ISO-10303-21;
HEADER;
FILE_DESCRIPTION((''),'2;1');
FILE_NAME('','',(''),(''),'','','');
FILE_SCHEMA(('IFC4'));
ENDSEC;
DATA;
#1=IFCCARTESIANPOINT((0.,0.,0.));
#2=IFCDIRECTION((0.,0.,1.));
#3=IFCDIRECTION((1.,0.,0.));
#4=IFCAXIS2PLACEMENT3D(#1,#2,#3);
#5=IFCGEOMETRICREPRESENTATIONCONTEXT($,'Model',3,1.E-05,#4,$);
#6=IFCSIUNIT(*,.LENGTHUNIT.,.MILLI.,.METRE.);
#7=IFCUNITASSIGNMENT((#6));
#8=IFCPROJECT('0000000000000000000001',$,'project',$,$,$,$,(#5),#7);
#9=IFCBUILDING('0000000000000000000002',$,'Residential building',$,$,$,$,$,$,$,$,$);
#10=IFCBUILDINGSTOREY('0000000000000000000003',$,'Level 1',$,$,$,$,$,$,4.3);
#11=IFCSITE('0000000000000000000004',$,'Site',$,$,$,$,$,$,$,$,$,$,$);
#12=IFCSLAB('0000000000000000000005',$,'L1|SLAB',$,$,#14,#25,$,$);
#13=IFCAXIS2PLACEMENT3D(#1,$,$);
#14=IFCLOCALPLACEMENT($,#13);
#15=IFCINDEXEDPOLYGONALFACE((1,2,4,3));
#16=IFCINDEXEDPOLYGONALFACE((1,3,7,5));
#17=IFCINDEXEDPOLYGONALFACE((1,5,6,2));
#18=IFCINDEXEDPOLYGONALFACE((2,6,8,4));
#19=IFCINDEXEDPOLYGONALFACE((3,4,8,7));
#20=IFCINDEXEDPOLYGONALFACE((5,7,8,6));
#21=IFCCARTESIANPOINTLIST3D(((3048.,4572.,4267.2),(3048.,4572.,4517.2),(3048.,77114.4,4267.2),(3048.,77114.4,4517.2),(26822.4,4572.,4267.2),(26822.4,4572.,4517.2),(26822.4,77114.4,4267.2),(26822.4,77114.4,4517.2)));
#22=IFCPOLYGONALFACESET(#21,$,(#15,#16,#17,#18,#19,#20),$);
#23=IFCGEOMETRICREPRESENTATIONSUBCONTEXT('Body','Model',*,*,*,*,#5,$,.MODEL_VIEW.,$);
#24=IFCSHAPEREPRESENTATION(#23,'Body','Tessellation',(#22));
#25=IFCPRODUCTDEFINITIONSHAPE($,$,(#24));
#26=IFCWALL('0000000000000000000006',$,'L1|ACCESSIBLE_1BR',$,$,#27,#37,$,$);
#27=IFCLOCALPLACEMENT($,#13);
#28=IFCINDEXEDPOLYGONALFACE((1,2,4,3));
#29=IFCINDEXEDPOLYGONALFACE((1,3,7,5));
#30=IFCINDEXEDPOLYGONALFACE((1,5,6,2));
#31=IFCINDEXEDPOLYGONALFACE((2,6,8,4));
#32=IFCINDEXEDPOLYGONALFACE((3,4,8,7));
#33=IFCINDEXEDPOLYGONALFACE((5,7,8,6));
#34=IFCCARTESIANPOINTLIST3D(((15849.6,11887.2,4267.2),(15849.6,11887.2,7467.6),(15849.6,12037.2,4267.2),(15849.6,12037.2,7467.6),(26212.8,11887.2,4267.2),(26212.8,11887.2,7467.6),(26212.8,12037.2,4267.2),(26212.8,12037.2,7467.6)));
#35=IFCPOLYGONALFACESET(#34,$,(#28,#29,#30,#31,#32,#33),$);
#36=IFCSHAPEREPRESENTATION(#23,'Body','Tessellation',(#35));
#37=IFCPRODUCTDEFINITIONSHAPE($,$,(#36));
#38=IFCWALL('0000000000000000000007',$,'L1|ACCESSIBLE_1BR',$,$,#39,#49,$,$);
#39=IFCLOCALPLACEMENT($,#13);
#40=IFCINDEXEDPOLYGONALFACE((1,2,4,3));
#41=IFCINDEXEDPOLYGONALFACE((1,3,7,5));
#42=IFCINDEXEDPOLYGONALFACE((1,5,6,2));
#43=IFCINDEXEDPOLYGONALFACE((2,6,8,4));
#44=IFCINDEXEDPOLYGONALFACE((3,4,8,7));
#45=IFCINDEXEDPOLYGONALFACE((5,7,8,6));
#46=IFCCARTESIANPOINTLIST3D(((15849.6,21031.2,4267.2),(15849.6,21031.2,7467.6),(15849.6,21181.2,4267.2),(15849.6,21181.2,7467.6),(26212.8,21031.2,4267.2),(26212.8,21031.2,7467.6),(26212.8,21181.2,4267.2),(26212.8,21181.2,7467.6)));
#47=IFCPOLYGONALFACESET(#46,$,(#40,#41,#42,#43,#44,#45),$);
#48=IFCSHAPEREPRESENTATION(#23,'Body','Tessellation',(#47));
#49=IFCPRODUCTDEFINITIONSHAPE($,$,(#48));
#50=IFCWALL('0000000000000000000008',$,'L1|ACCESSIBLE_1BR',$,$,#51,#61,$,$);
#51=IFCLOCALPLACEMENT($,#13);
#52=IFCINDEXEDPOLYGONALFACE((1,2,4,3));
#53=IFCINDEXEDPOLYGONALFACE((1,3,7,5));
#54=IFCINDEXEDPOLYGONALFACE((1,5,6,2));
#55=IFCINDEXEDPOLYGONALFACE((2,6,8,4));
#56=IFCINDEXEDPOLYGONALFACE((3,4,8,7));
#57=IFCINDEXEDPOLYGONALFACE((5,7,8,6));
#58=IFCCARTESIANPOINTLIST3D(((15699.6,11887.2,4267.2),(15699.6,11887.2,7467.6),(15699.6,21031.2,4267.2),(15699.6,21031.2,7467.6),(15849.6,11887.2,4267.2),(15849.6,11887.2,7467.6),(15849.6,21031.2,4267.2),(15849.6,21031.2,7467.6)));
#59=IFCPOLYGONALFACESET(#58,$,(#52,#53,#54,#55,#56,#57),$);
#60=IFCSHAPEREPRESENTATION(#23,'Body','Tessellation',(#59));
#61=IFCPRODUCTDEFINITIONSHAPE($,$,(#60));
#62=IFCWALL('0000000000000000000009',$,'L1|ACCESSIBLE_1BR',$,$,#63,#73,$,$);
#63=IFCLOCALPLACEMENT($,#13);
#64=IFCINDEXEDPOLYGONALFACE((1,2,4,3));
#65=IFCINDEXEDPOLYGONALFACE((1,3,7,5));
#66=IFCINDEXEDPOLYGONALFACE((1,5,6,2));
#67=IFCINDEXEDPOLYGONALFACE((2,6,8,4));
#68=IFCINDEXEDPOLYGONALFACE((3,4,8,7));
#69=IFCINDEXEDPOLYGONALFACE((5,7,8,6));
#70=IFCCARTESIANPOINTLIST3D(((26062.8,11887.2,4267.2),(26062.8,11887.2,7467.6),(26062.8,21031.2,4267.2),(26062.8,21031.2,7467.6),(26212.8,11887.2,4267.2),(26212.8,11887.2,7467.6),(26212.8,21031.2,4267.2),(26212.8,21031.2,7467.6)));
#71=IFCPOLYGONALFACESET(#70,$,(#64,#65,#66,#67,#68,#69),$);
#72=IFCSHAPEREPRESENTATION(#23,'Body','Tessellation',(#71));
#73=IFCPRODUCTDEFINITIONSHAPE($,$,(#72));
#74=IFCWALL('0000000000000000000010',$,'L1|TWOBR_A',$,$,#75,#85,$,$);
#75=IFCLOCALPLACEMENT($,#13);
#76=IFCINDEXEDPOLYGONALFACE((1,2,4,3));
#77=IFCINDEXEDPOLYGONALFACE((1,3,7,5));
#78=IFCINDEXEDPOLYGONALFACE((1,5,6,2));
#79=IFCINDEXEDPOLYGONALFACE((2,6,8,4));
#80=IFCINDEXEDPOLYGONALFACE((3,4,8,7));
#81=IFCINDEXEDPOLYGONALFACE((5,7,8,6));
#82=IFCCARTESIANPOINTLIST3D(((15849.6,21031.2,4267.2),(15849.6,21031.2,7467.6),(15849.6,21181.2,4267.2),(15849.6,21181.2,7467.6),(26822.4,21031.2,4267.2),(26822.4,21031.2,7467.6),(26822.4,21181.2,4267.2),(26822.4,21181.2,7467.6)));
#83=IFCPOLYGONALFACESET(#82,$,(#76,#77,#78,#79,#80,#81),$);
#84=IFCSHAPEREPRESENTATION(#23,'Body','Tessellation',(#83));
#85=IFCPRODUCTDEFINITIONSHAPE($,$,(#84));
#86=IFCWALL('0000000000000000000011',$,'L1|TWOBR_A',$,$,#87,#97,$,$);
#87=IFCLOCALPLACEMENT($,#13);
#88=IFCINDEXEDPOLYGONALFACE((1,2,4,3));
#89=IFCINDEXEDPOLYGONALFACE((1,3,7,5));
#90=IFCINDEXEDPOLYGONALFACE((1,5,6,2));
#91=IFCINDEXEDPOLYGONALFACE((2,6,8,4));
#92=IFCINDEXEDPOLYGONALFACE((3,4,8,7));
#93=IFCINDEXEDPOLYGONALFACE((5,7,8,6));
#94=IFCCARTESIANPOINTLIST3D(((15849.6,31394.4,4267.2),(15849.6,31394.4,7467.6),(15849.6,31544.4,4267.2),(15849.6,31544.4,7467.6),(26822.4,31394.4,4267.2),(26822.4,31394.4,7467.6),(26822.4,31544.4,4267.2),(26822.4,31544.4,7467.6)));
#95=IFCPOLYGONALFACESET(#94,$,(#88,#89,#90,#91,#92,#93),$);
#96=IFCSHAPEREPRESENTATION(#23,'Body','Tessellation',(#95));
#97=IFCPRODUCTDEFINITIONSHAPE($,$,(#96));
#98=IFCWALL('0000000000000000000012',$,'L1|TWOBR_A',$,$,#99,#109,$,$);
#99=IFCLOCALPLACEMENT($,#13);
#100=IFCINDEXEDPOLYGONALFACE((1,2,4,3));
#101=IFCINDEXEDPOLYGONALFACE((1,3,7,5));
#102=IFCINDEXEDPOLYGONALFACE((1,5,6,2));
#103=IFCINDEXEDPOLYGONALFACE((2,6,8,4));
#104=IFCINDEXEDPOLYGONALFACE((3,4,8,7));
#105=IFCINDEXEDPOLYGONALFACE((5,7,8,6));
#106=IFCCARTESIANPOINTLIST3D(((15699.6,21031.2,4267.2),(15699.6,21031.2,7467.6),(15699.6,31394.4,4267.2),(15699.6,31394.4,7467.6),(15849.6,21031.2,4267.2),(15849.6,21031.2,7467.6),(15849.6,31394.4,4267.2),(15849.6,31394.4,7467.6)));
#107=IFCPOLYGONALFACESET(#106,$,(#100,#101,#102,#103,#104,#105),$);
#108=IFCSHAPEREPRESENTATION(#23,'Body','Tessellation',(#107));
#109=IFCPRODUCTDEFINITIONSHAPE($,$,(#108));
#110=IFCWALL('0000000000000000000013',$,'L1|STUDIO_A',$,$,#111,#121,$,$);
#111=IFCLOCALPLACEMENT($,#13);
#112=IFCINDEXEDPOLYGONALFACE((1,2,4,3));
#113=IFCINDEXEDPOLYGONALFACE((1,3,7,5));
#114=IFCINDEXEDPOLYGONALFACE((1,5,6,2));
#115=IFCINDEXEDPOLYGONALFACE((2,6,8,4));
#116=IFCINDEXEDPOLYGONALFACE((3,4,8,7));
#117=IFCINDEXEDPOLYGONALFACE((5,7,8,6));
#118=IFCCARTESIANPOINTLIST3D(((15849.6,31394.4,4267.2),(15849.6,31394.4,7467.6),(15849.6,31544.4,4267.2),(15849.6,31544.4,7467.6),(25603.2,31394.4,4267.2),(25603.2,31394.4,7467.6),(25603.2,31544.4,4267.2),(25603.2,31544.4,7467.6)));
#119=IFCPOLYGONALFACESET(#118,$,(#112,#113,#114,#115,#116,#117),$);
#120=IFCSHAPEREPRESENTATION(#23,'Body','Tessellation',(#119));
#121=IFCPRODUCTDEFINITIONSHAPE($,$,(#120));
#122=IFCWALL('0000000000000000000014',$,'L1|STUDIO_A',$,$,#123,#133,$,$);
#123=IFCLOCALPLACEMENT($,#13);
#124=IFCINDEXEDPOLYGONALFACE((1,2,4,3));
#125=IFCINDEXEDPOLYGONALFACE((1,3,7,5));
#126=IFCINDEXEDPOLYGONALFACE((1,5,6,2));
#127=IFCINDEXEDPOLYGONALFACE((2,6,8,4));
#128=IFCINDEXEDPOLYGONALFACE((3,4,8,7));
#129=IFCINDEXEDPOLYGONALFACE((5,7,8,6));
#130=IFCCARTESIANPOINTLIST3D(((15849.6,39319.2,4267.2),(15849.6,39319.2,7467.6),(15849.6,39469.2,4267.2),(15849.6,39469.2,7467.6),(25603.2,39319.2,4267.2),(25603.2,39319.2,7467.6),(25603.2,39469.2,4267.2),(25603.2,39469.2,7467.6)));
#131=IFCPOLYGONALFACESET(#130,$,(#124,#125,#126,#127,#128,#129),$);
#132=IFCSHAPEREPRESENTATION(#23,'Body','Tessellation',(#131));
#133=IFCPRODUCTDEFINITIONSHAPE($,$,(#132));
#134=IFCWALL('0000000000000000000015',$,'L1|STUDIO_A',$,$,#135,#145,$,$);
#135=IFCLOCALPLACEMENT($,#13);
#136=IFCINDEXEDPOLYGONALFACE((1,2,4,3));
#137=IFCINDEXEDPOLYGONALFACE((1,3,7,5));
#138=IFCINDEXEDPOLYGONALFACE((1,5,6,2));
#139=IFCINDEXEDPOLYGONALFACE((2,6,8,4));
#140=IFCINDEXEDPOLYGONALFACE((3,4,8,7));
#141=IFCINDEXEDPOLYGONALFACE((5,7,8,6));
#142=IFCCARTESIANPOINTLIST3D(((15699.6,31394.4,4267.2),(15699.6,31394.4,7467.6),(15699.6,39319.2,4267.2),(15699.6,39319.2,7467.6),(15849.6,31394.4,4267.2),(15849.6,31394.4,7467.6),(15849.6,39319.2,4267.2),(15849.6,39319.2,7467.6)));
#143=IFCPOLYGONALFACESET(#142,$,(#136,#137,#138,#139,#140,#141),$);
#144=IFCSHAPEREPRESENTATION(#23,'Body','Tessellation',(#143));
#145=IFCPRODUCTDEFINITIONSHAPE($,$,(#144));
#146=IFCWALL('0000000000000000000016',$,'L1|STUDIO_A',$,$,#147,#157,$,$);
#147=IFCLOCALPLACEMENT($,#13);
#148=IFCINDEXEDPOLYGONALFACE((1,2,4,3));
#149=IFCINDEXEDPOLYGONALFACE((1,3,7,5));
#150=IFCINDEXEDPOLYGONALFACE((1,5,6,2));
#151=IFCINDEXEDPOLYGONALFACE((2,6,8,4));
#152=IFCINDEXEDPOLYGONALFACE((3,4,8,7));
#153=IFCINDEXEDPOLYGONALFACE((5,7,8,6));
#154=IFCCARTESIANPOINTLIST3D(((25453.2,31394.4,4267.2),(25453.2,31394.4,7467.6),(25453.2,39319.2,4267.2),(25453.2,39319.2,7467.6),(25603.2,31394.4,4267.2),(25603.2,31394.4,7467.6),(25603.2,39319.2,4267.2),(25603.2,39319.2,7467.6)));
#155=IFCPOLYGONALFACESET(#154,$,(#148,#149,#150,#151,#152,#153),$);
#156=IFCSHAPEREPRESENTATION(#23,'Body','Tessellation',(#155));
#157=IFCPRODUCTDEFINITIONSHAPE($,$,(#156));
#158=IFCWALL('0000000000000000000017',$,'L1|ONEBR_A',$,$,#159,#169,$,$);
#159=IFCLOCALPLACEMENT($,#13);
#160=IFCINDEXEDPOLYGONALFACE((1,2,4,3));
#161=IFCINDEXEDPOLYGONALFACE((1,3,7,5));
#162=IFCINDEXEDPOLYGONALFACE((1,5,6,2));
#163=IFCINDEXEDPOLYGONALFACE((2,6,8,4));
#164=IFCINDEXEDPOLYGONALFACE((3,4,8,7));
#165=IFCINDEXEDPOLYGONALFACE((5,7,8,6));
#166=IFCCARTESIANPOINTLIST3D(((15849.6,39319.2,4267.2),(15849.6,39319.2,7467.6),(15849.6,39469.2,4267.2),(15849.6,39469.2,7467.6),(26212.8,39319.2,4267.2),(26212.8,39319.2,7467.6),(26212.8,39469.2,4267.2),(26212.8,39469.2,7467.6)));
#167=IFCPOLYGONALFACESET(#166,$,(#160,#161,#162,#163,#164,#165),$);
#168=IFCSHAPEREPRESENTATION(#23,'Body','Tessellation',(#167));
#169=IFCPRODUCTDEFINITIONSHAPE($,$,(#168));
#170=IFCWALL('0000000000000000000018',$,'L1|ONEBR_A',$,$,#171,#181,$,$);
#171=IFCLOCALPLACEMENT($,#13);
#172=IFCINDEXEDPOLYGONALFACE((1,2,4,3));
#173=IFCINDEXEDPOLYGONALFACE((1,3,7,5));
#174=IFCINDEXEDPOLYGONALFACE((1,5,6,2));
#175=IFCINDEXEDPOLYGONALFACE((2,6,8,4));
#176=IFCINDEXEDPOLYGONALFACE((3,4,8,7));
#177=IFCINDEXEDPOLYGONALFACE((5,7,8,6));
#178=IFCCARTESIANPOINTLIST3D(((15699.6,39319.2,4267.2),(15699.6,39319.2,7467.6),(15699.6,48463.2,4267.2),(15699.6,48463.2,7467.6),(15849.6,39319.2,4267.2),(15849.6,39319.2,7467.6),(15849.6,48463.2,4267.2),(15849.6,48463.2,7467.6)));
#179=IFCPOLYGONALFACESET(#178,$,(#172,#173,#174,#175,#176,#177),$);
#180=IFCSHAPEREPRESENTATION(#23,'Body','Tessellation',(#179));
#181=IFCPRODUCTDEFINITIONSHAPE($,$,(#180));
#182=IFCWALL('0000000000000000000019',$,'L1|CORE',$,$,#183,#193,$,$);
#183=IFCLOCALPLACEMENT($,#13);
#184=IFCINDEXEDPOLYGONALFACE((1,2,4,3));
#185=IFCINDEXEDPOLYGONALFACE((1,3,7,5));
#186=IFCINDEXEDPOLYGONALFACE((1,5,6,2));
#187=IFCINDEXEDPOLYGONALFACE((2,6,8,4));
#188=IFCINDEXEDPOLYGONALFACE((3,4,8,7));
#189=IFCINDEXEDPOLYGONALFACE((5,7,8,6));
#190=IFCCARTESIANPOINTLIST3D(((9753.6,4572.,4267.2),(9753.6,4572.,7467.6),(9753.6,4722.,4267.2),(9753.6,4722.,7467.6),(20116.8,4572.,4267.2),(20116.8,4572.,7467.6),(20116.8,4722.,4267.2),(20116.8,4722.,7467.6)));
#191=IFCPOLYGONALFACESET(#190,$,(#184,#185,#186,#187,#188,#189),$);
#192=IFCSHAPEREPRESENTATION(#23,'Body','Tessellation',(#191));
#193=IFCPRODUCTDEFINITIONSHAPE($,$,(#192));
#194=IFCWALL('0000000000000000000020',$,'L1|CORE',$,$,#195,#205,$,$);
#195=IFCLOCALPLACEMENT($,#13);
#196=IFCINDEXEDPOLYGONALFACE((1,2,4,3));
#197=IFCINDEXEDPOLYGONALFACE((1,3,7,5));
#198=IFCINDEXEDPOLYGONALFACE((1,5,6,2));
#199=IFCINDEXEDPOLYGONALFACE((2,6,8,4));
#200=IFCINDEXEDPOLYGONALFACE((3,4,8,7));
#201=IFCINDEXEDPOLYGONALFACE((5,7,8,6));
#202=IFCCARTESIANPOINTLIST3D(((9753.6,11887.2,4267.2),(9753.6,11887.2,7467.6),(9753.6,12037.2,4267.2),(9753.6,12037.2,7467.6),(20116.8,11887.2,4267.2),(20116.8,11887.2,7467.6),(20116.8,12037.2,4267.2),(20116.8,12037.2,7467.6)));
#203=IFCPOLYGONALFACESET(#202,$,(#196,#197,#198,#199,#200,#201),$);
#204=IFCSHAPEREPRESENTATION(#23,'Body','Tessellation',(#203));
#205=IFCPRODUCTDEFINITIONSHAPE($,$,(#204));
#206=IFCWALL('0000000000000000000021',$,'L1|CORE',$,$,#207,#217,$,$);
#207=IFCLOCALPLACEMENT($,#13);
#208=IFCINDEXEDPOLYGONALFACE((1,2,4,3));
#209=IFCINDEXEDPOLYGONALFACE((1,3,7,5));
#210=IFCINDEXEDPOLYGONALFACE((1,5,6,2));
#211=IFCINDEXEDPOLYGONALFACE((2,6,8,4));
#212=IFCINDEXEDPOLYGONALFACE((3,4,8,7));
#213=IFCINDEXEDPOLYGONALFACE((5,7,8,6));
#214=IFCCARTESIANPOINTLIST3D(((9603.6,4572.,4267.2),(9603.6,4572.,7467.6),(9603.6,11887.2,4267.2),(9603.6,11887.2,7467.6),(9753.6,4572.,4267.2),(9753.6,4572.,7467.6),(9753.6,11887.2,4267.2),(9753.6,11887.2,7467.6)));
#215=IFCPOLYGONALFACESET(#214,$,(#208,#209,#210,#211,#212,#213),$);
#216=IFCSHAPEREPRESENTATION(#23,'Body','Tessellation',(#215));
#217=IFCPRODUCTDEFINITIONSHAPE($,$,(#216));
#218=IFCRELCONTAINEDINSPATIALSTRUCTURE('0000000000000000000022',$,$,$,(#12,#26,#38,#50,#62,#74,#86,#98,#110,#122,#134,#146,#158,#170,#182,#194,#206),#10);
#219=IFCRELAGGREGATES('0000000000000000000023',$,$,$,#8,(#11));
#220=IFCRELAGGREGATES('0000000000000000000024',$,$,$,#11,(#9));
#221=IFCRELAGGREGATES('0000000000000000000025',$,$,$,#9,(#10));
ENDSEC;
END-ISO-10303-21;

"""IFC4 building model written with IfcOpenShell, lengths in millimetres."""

from ifc_helpers import new_model, si_unit, frame, origin_with_axes, place, context, subcontext, project, spatial, indexed_curve, outline, extrude, element, save


model = new_model("IFC4")

# Units and contexts
model_context = context("Model", 3, precision=1e-05, world=origin_with_axes())
body_context = subcontext(model_context, "Body", "Model", "MODEL_VIEW")
ifc_project = project(units=[si_unit("LENGTHUNIT", "METRE", prefix="MILLI")], contexts=[model_context])

# Site, building, storey
site = spatial("IfcSite", under=ifc_project, Name="Site")
building = spatial("IfcBuilding", under=site, Name="Residential building")
storey = spatial("IfcBuildingStorey", under=building, Name="Level 1", Elevation=4.3)

# Slab
slab_placement = place(None, frame((3048.0, 4572.0, 4267.2), z_axis=(0.0, 0.0, 1.0), x_axis=(1.0, 0.0, 0.0)))
element("IfcSlab", 1, at=slab_placement, inside=storey, Name="L1|SLAB", context=body_context, shape_type="SweptSolid", body=[
    extrude(outline(indexed_curve([(0.0, 0.0), (23774.4, 0.0), (23774.4, 72542.4), (0.0, 72542.4), (0.0, 0.0)])), None, (0.0, 0.0, 1.0), 250.0),
])

# Walls
for number, where, z_axis, x_axis, name in (
    (2, (15849.6, 11887.2, 4267.2), (0.0, 0.0, 1.0), (1.0, 0.0, 0.0), "L1|ACCESSIBLE_1BR"),
    (3, (15849.6, 21031.2, 4267.2), (0.0, 0.0, 1.0), (1.0, 0.0, 0.0), "L1|ACCESSIBLE_1BR"),
):
    element("IfcWall", number, at=place(None, frame(where, z_axis=z_axis, x_axis=x_axis)), inside=storey, Name=name, context=body_context, shape_type="SweptSolid", body=[
        extrude(outline(indexed_curve([(0.0, 0.0), (0.0, 150.0), (10363.2, 150.0), (10363.2, 0.0), (0.0, 0.0)], self_intersect=False)), origin_with_axes(), (0.0, 0.0, 1.0), 3200.4),
    ])
for number, where, z_axis, x_axis, name in (
    (4, (15849.6, 11887.2, 4267.2), (0.0, 0.0, 1.0), (0.0, 1.0, 0.0), "L1|ACCESSIBLE_1BR"),
    (5, (26212.8, 11887.2, 4267.2), (0.0, 0.0, 1.0), (0.0, 1.0, 0.0), "L1|ACCESSIBLE_1BR"),
):
    element("IfcWall", number, at=place(None, frame(where, z_axis=z_axis, x_axis=x_axis)), inside=storey, Name=name, context=body_context, shape_type="SweptSolid", body=[
        extrude(outline(indexed_curve([(0.0, 0.0), (0.0, 150.0), (9144.0, 150.0), (9144.0, 0.0), (0.0, 0.0)], self_intersect=False)), origin_with_axes(), (0.0, 0.0, 1.0), 3200.4),
    ])
for number, where, z_axis, x_axis, name in (
    (6, (15849.6, 21031.2, 4267.2), (0.0, 0.0, 1.0), (1.0, 0.0, 0.0), "L1|TWOBR_A"),
    (7, (15849.6, 31394.4, 4267.2), (0.0, 0.0, 1.0), (1.0, 0.0, 0.0), "L1|TWOBR_A"),
):
    element("IfcWall", number, at=place(None, frame(where, z_axis=z_axis, x_axis=x_axis)), inside=storey, Name=name, context=body_context, shape_type="SweptSolid", body=[
        extrude(outline(indexed_curve([(0.0, 0.0), (0.0, 150.0), (10972.8, 150.0), (10972.8, 0.0), (0.0, 0.0)], self_intersect=False)), origin_with_axes(), (0.0, 0.0, 1.0), 3200.4),
    ])
wall_1_placement = place(None, frame((15849.6, 21031.2, 4267.2), z_axis=(0.0, 0.0, 1.0), x_axis=(0.0, 1.0, 0.0)))
element("IfcWall", 8, at=wall_1_placement, inside=storey, Name="L1|TWOBR_A", context=body_context, shape_type="SweptSolid", body=[
    extrude(outline(indexed_curve([(0.0, 0.0), (0.0, 150.0), (10363.2, 150.0), (10363.2, 0.0), (0.0, 0.0)], self_intersect=False)), origin_with_axes(), (0.0, 0.0, 1.0), 3200.4),
])
for number, where, z_axis, x_axis, name in (
    (9, (15849.6, 31394.4, 4267.2), (0.0, 0.0, 1.0), (1.0, 0.0, 0.0), "L1|STUDIO_A"),
    (10, (15849.6, 39319.2, 4267.2), (0.0, 0.0, 1.0), (1.0, 0.0, 0.0), "L1|STUDIO_A"),
):
    element("IfcWall", number, at=place(None, frame(where, z_axis=z_axis, x_axis=x_axis)), inside=storey, Name=name, context=body_context, shape_type="SweptSolid", body=[
        extrude(outline(indexed_curve([(0.0, 0.0), (0.0, 150.0), (9753.6, 150.0), (9753.6, 0.0), (0.0, 0.0)], self_intersect=False)), origin_with_axes(), (0.0, 0.0, 1.0), 3200.4),
    ])
for number, where, z_axis, x_axis, name in (
    (11, (15849.6, 31394.4, 4267.2), (0.0, 0.0, 1.0), (0.0, 1.0, 0.0), "L1|STUDIO_A"),
    (12, (25603.2, 31394.4, 4267.2), (0.0, 0.0, 1.0), (0.0, 1.0, 0.0), "L1|STUDIO_A"),
):
    element("IfcWall", number, at=place(None, frame(where, z_axis=z_axis, x_axis=x_axis)), inside=storey, Name=name, context=body_context, shape_type="SweptSolid", body=[
        extrude(outline(indexed_curve([(0.0, 0.0), (0.0, 150.0), (7924.8, 150.0), (7924.8, 0.0), (0.0, 0.0)], self_intersect=False)), origin_with_axes(), (0.0, 0.0, 1.0), 3200.4),
    ])
wall_2_placement = place(None, frame((15849.6, 39319.2, 4267.2), z_axis=(0.0, 0.0, 1.0), x_axis=(1.0, 0.0, 0.0)))
element("IfcWall", 13, at=wall_2_placement, inside=storey, Name="L1|ONEBR_A", context=body_context, shape_type="SweptSolid", body=[
    extrude(outline(indexed_curve([(0.0, 0.0), (0.0, 150.0), (10363.2, 150.0), (10363.2, 0.0), (0.0, 0.0)], self_intersect=False)), origin_with_axes(), (0.0, 0.0, 1.0), 3200.4),
])
wall_3_placement = place(None, frame((15849.6, 39319.2, 4267.2), z_axis=(0.0, 0.0, 1.0), x_axis=(0.0, 1.0, 0.0)))
element("IfcWall", 14, at=wall_3_placement, inside=storey, Name="L1|ONEBR_A", context=body_context, shape_type="SweptSolid", body=[
    extrude(outline(indexed_curve([(0.0, 0.0), (0.0, 150.0), (9144.0, 150.0), (9144.0, 0.0), (0.0, 0.0)], self_intersect=False)), origin_with_axes(), (0.0, 0.0, 1.0), 3200.4),
])
for number, where, z_axis, x_axis, name in (
    (15, (9753.6, 4572.0, 4267.2), (0.0, 0.0, 1.0), (1.0, 0.0, 0.0), "L1|CORE"),
    (16, (9753.6, 11887.2, 4267.2), (0.0, 0.0, 1.0), (1.0, 0.0, 0.0), "L1|CORE"),
):
    element("IfcWall", number, at=place(None, frame(where, z_axis=z_axis, x_axis=x_axis)), inside=storey, Name=name, context=body_context, shape_type="SweptSolid", body=[
        extrude(outline(indexed_curve([(0.0, 0.0), (0.0, 150.0), (10363.2, 150.0), (10363.2, 0.0), (0.0, 0.0)], self_intersect=False)), origin_with_axes(), (0.0, 0.0, 1.0), 3200.4),
    ])
for number, where, z_axis, x_axis, name in (
    (17, (9753.6, 4572.0, 4267.2), (0.0, 0.0, 1.0), (0.0, 1.0, 0.0), "L1|CORE"),
):
    element("IfcWall", number, at=place(None, frame(where, z_axis=z_axis, x_axis=x_axis)), inside=storey, Name=name, context=body_context, shape_type="SweptSolid", body=[
        extrude(outline(indexed_curve([(0.0, 0.0), (0.0, 150.0), (7315.2, 150.0), (7315.2, 0.0), (0.0, 0.0)], self_intersect=False)), origin_with_axes(), (0.0, 0.0, 1.0), 3200.4),
    ])

save(model, "model.ifc")
